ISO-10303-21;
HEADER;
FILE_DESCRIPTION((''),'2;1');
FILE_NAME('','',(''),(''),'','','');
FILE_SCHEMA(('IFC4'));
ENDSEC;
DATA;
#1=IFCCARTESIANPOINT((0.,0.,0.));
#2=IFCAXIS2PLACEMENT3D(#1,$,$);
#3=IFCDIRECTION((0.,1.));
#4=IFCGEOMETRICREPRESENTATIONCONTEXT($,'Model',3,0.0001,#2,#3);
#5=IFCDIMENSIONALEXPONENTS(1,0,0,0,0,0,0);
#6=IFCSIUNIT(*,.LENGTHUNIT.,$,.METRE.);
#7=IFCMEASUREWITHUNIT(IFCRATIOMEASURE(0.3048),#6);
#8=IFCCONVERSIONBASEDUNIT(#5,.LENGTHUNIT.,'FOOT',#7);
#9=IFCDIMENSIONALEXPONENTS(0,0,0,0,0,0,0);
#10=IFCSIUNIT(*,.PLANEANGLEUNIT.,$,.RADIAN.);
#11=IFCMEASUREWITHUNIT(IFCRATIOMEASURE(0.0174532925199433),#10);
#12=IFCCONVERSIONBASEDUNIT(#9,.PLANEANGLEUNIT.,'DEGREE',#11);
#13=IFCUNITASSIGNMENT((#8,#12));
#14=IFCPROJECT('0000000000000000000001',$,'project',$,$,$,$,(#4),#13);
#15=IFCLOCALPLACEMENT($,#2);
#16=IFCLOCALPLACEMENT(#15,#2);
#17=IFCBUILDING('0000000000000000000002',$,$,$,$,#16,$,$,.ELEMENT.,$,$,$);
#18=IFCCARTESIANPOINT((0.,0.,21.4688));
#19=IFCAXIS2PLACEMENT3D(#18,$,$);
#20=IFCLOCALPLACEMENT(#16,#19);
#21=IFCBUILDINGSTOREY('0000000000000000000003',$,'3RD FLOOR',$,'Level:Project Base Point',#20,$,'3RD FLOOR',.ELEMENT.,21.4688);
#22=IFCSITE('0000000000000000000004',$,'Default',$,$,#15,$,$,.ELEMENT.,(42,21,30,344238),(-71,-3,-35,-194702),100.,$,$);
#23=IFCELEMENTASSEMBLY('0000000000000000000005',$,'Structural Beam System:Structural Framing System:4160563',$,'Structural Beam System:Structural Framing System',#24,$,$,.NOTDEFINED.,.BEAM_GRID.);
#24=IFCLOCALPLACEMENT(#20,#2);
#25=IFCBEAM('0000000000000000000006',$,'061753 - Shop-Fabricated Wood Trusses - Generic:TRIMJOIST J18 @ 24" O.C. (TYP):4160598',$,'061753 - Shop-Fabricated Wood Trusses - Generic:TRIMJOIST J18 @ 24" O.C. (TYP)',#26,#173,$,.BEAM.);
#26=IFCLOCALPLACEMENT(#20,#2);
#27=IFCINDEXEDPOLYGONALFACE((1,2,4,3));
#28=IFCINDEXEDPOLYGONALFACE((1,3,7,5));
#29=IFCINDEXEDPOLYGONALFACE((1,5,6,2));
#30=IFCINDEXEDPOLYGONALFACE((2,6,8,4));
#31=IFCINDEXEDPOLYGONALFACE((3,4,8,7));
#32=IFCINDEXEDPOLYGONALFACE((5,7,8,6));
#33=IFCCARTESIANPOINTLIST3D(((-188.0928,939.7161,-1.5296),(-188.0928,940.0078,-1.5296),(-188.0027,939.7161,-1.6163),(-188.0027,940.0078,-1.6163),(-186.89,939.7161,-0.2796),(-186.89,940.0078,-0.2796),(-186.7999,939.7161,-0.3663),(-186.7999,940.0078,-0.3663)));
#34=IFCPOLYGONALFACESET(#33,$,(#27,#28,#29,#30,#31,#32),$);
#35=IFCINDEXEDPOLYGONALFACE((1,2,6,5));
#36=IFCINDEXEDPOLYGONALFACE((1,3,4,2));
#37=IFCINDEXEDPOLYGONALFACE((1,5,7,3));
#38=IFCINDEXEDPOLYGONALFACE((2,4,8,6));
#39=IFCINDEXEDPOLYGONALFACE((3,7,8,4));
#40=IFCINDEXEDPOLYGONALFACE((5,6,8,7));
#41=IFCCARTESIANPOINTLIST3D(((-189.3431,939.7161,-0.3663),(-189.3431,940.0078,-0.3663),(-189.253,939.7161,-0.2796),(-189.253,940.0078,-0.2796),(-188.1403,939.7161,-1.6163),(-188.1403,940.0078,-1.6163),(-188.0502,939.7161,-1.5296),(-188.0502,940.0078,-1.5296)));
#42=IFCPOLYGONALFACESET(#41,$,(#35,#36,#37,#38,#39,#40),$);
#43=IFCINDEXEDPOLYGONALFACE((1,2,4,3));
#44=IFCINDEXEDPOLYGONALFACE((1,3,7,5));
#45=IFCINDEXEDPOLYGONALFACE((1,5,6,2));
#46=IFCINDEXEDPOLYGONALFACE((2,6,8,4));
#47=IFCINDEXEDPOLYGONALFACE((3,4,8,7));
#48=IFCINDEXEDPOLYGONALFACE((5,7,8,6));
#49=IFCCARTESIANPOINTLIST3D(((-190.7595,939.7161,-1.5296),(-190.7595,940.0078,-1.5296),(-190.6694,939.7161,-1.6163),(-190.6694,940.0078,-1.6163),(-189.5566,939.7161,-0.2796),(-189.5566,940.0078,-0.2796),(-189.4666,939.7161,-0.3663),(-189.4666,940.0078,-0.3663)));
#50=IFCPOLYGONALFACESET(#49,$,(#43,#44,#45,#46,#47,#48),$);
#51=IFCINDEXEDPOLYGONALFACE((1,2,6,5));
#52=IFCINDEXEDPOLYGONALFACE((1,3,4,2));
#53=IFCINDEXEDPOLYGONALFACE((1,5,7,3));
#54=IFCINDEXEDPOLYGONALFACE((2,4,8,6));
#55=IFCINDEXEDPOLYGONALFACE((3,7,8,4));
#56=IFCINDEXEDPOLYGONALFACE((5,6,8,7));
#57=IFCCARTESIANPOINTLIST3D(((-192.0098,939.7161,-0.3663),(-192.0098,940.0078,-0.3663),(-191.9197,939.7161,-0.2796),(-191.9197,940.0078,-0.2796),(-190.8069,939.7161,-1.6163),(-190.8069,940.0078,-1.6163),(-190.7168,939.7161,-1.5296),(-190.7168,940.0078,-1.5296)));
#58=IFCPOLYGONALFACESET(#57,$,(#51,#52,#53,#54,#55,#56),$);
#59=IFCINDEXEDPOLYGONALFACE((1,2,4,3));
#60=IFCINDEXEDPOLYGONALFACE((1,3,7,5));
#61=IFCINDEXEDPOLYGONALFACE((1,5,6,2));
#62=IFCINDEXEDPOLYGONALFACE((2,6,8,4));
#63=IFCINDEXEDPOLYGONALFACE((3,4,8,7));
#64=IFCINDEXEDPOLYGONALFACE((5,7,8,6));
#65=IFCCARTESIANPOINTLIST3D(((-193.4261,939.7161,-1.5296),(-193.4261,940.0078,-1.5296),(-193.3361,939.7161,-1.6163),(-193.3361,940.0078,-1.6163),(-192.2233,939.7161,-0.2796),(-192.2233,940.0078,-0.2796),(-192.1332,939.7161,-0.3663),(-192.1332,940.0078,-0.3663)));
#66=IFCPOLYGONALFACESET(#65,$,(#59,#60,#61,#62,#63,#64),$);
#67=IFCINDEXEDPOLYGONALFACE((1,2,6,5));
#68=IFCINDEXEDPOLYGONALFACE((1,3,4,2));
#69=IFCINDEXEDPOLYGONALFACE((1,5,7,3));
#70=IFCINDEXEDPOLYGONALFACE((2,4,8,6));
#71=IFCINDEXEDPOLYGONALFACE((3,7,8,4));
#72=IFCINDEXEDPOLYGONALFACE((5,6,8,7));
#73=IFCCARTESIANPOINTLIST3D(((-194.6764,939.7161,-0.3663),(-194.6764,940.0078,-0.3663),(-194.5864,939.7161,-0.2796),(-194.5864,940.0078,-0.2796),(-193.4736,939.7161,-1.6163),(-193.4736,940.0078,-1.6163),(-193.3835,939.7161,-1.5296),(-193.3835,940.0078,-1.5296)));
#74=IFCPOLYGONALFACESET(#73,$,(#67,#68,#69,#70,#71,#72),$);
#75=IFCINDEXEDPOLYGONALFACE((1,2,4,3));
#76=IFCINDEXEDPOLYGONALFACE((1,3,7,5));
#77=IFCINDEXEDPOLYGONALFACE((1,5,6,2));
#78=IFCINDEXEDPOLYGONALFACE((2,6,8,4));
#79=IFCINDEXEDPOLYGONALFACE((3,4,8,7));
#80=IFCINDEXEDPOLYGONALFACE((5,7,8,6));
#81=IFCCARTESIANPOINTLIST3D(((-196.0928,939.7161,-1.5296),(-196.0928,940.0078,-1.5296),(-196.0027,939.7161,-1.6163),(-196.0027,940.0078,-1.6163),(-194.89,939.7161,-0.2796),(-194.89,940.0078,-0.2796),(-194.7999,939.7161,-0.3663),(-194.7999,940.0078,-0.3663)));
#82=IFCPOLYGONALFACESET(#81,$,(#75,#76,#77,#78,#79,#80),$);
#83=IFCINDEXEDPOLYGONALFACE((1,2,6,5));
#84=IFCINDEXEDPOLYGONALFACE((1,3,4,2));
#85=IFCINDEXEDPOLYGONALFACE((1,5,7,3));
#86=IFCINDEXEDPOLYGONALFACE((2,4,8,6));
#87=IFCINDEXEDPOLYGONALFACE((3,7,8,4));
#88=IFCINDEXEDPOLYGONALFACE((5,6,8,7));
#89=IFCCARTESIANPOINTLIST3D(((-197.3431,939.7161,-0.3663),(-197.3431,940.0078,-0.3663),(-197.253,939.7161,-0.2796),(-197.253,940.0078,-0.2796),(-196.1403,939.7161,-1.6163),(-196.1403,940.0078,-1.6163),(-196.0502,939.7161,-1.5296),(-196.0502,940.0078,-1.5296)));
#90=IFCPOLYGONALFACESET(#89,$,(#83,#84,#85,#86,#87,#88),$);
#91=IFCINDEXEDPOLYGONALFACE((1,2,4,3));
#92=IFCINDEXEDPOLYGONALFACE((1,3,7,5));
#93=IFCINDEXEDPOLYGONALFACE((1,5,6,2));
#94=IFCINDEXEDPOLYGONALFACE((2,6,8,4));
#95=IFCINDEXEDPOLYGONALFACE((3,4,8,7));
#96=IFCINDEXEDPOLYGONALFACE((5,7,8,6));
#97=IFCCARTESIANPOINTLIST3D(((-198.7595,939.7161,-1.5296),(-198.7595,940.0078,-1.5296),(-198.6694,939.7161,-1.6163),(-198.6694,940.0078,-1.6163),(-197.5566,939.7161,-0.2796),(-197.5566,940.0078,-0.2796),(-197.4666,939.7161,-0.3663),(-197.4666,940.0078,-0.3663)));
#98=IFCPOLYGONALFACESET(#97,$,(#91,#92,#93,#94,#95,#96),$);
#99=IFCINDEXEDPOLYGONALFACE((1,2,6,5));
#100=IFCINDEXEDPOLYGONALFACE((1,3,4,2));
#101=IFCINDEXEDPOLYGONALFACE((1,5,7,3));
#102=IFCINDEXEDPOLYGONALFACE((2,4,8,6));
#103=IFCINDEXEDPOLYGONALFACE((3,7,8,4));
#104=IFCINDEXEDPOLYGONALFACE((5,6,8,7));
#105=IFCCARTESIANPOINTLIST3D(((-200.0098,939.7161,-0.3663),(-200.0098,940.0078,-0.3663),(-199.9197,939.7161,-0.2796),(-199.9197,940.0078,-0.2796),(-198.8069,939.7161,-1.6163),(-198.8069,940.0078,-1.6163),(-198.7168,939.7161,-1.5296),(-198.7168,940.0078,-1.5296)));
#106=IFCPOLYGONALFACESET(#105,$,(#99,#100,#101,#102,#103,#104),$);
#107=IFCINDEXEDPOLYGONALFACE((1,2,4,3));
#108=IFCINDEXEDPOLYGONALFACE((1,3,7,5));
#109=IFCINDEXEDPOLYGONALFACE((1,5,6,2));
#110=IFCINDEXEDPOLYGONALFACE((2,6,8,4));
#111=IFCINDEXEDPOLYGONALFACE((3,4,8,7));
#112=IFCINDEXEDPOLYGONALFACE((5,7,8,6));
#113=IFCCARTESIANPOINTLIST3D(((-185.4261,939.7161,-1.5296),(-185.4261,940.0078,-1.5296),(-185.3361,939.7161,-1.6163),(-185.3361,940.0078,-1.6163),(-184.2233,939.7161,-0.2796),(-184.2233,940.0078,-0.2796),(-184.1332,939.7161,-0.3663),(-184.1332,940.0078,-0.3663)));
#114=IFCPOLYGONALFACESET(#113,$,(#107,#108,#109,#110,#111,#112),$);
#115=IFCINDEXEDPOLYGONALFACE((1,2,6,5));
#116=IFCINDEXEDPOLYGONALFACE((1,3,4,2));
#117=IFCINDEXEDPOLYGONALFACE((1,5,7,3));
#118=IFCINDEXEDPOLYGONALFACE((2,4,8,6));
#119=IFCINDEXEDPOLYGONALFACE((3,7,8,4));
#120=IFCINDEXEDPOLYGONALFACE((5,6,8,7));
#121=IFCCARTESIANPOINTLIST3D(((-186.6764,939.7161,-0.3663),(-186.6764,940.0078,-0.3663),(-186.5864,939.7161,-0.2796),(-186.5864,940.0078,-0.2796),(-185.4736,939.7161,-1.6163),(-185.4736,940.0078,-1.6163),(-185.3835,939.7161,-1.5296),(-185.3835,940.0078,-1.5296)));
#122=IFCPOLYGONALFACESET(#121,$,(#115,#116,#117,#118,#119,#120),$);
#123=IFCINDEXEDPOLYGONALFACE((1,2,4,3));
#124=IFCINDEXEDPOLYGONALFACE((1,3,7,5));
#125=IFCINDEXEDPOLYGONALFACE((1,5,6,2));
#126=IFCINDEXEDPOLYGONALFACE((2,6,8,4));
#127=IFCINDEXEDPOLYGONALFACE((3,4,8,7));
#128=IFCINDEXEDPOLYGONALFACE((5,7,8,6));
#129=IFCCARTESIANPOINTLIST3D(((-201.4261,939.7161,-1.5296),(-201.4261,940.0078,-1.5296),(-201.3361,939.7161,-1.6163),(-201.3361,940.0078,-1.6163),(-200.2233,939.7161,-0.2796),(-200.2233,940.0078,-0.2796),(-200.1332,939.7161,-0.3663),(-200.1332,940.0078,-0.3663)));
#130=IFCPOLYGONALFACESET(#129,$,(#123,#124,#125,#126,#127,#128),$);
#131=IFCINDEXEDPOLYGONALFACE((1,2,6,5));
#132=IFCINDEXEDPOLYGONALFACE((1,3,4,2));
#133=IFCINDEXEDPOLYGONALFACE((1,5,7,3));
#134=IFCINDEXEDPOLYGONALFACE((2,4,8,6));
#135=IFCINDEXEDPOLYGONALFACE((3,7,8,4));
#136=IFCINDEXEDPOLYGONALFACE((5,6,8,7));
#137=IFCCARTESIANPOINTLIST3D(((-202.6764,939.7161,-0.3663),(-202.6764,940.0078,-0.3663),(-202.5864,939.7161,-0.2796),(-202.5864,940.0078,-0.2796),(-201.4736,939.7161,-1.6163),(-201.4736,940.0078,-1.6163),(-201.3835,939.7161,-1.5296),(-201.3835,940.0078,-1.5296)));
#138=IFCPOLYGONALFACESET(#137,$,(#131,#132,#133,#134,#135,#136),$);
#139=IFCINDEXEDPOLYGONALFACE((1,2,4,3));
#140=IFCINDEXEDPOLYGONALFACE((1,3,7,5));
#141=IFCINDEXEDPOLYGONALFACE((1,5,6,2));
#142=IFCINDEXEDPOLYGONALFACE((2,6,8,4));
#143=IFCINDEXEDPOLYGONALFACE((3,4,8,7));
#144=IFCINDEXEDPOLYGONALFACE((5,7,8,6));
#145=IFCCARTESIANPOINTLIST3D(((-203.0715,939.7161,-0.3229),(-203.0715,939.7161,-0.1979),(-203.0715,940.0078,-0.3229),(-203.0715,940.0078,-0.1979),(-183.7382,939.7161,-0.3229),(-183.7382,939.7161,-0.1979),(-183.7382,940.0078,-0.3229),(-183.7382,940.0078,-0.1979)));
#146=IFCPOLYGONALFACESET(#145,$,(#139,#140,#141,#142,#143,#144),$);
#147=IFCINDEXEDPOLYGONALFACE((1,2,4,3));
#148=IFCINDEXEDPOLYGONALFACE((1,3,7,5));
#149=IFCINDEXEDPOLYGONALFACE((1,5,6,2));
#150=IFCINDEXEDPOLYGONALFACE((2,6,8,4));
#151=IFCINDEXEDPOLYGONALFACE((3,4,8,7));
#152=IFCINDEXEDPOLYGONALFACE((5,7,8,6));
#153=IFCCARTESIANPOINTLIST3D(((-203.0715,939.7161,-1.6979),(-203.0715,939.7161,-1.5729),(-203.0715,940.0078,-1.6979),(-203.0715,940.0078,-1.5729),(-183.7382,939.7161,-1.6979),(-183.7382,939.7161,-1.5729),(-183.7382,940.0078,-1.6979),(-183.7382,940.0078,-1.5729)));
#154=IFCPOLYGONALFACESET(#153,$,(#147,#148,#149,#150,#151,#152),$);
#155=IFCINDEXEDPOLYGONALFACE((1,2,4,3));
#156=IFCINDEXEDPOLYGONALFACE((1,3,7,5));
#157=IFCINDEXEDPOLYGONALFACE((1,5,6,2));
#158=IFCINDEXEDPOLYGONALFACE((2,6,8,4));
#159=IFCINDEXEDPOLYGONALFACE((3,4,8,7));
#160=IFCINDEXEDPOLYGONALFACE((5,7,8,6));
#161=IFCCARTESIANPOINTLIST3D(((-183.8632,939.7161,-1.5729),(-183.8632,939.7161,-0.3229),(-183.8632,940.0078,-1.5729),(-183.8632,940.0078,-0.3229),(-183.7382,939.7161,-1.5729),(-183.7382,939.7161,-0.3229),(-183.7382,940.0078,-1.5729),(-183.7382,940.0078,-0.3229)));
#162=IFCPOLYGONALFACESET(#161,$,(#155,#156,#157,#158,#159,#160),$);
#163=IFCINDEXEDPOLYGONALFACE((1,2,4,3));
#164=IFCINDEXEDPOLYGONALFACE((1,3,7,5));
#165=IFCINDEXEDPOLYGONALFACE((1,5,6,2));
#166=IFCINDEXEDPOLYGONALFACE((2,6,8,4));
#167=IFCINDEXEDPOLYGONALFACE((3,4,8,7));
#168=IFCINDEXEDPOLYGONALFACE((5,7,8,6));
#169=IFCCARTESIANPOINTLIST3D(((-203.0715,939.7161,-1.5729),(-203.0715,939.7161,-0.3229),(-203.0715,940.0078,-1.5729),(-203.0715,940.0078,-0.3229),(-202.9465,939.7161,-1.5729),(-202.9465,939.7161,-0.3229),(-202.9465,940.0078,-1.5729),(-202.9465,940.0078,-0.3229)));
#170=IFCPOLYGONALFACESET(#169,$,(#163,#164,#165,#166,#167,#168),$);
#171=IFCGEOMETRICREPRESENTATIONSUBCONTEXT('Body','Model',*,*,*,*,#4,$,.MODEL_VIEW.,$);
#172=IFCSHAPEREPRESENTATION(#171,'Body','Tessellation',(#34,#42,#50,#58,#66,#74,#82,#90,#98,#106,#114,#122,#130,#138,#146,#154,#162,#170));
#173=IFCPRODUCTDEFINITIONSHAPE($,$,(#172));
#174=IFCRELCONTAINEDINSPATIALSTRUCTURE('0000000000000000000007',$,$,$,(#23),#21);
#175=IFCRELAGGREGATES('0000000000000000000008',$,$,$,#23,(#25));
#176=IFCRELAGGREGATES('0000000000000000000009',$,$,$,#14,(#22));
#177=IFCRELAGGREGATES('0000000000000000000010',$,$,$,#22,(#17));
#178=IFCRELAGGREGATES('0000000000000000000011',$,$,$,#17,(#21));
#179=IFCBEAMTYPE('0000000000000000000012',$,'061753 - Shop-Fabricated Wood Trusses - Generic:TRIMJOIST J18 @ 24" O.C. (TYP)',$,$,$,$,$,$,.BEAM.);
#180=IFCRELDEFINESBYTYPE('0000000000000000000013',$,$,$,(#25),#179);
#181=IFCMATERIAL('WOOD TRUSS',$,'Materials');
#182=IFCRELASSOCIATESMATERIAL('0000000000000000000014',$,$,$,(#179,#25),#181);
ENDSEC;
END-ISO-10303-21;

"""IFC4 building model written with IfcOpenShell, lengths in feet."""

from ifc_helpers import new_model, entity, si_unit, converted_unit, direction, frame, frame_2d, origin, origin_2d_with_axis, place, context, subcontext, project, spatial, rectangle, extrude, source, transform, mapped, material, material_profile, profile_set, profile_usage, type_object, type_shapes, element, aggregate, save


model = new_model("IFC4")

# Units and contexts
model_context = context("Model", 3, precision=0.0001, world=origin(), true_north=direction((0.0, 1.0)))
body_context = subcontext(model_context, "Body", "Model", "MODEL_VIEW")
ifc_project = project(units=[converted_unit("LENGTHUNIT", "FOOT", entity("IfcRatioMeasure", 0.3048), si_unit("LENGTHUNIT", "METRE"), dimensions=[1, 0, 0, 0, 0, 0, 0]), converted_unit("PLANEANGLEUNIT", "DEGREE", entity("IfcRatioMeasure", 0.0174532925199433), si_unit("PLANEANGLEUNIT", "RADIAN"), dimensions=[0, 0, 0, 0, 0, 0, 0])], contexts=[model_context])

# Site, building, storey
site_placement = place(None, origin())
site = spatial("IfcSite", under=ifc_project, at=site_placement, Name="Default", CompositionType="ELEMENT", RefLatitude=(42, 21, 30, 344238), RefLongitude=(-71, -3, -35, -194702), RefElevation=100.0)
building_placement = place(site_placement, origin())
building = spatial("IfcBuilding", under=site, at=building_placement, CompositionType="ELEMENT")
storey_placement = place(building_placement, frame((0.0, 0.0, 21.4688)))
storey = spatial("IfcBuildingStorey", under=building, at=storey_placement, Name="3RD FLOOR", ObjectType="Level:Project Base Point", LongName="3RD FLOOR", CompositionType="ELEMENT", Elevation=21.4688)

# Element assembly, beam
ifc_material = material(Name="WOOD TRUSS", Category="Materials")
ifc_material_profile_1 = material_profile(ifc_material, rectangle(XDim=1.7347, YDim=0.125, at=frame_2d((0.0, 0.0), x_axis=(1.0, 0.0))), Name="TRIMJOIST J18 @ 24\" O.C. (TYP)")
ifc_material_profile_2 = material_profile(ifc_material, rectangle(XDim=1.7347, YDim=0.125, at=frame_2d((0.0, 0.0), x_axis=(1.0, 0.0))), Name="TRIMJOIST J18 @ 24\" O.C. (TYP)")
ifc_material_profile_3 = material_profile(ifc_material, rectangle(XDim=1.7347, YDim=0.125, at=frame_2d((0.0, 0.0), x_axis=(1.0, 0.0))), Name="TRIMJOIST J18 @ 24\" O.C. (TYP)")
ifc_material_profile_4 = material_profile(ifc_material, rectangle(XDim=1.7347, YDim=0.125, at=frame_2d((0.0, 0.0), x_axis=(1.0, 0.0))), Name="TRIMJOIST J18 @ 24\" O.C. (TYP)")
ifc_material_profile_5 = material_profile(ifc_material, rectangle(XDim=1.7347, YDim=0.125, at=frame_2d((0.0, 0.0), x_axis=(1.0, 0.0))), Name="TRIMJOIST J18 @ 24\" O.C. (TYP)")
ifc_material_profile_6 = material_profile(ifc_material, rectangle(XDim=1.7347, YDim=0.125, at=frame_2d((0.0, 0.0), x_axis=(1.0, 0.0))), Name="TRIMJOIST J18 @ 24\" O.C. (TYP)")
ifc_material_profile_7 = material_profile(ifc_material, rectangle(XDim=1.7347, YDim=0.125, at=frame_2d((0.0, 0.0), x_axis=(1.0, 0.0))), Name="TRIMJOIST J18 @ 24\" O.C. (TYP)")
ifc_material_profile_8 = material_profile(ifc_material, rectangle(XDim=1.7347, YDim=0.125, at=frame_2d((0.0, 0.0), x_axis=(1.0, 0.0))), Name="TRIMJOIST J18 @ 24\" O.C. (TYP)")
ifc_material_profile_9 = material_profile(ifc_material, rectangle(XDim=1.7347, YDim=0.125, at=frame_2d((0.0, 0.0), x_axis=(1.0, 0.0))), Name="TRIMJOIST J18 @ 24\" O.C. (TYP)")
ifc_material_profile_10 = material_profile(ifc_material, rectangle(XDim=1.7347, YDim=0.125, at=origin_2d_with_axis()), Name="TRIMJOIST J18 @ 24\" O.C. (TYP)")
ifc_material_profile_11 = material_profile(ifc_material, rectangle(XDim=0.125, YDim=0.2917, at=origin_2d_with_axis()), Name="TRIMJOIST J18 @ 24\" O.C. (TYP)")
ifc_material_profile_12 = material_profile(ifc_material, rectangle(XDim=0.125, YDim=0.2917, at=origin_2d_with_axis()), Name="TRIMJOIST J18 @ 24\" O.C. (TYP)")
ifc_material_profile_13 = material_profile(ifc_material, rectangle(XDim=1.25, YDim=0.2917, at=origin_2d_with_axis()), Name="TRIMJOIST J18 @ 24\" O.C. (TYP)")
ifc_material_profile_14 = material_profile(ifc_material, rectangle(XDim=1.25, YDim=0.2917, at=origin_2d_with_axis()), Name="TRIMJOIST J18 @ 24\" O.C. (TYP)")
ifc_profile_set = profile_set([ifc_material_profile_1, ifc_material_profile_2, ifc_material_profile_3, ifc_material_profile_4, ifc_material_profile_5, ifc_material_profile_6, ifc_material_profile_7, ifc_material_profile_8, ifc_material_profile_9, ifc_material_profile_10, ifc_material_profile_11, ifc_material_profile_12, ifc_material_profile_13, ifc_material_profile_14], Name="TRIMJOIST J18 @ 24\" O.C. (TYP)")
beam_type_1 = type_object("IfcBeamType", Name="061753 - Shop-Fabricated Wood Trusses - Generic:TRIMJOIST J18 @ 24\" O.C. (TYP)", PredefinedType="BEAM", material=ifc_profile_set)
shared_shape_1 = source(origin(), body_context, "Body", "SweptSolid", [
    extrude(rectangle(XDim=1.7347, YDim=0.125, at=frame_2d((0.0, 0.0), x_axis=(1.0, 0.0))), frame((5.9585, -0.1458, 0.0), z_axis=(0.0, 1.0, 0.0), x_axis=(0.693383, 0.0, 0.720569)), (0.0, 0.0, 1.0), 0.2917),
    extrude(rectangle(XDim=1.7347, YDim=0.125, at=origin_2d_with_axis()), frame((4.7082, -0.1458, 0.0), z_axis=(0.0, 1.0, 0.0), x_axis=(0.693383, 0.0, -0.720569)), (0.0, 0.0, 1.0), 0.2917),
    extrude(rectangle(XDim=1.7347, YDim=0.125, at=frame_2d((0.0, 0.0), x_axis=(1.0, 0.0))), frame((3.2918, -0.1458, 0.0), z_axis=(0.0, 1.0, 0.0), x_axis=(0.693383, 0.0, 0.720569)), (0.0, 0.0, 1.0), 0.2917),
    extrude(rectangle(XDim=1.7347, YDim=0.125, at=frame_2d((0.0, 0.0), x_axis=(1.0, 0.0))), frame((2.0415, -0.1458, 0.0), z_axis=(0.0, 1.0, 0.0), x_axis=(0.693383, 0.0, -0.720569)), (0.0, 0.0, 1.0), 0.2917),
    extrude(rectangle(XDim=1.7347, YDim=0.125, at=frame_2d((0.0, 0.0), x_axis=(1.0, 0.0))), frame((0.6251, -0.1458, 0.0), z_axis=(0.0, 1.0, 0.0), x_axis=(0.693383, 0.0, 0.720569)), (0.0, 0.0, 1.0), 0.2917),
    extrude(rectangle(XDim=1.7347, YDim=0.125, at=frame_2d((0.0, 0.0), x_axis=(1.0, 0.0))), frame((-0.6251, -0.1458, 0.0), z_axis=(0.0, 1.0, 0.0), x_axis=(0.693383, 0.0, -0.720569)), (0.0, 0.0, 1.0), 0.2917),
    extrude(rectangle(XDim=1.7347, YDim=0.125, at=frame_2d((0.0, 0.0), x_axis=(1.0, 0.0))), frame((-2.0415, -0.1458, 0.0), z_axis=(0.0, 1.0, 0.0), x_axis=(0.693383, 0.0, 0.720569)), (0.0, 0.0, 1.0), 0.2917),
    extrude(rectangle(XDim=1.7347, YDim=0.125, at=origin_2d_with_axis()), frame((-3.2918, -0.1458, 0.0), z_axis=(0.0, 1.0, 0.0), x_axis=(0.693383, 0.0, -0.720569)), (0.0, 0.0, 1.0), 0.2917),
    extrude(rectangle(XDim=1.7347, YDim=0.125, at=frame_2d((0.0, 0.0), x_axis=(1.0, 0.0))), frame((-4.7082, -0.1458, 0.0), z_axis=(0.0, 1.0, 0.0), x_axis=(0.693383, 0.0, 0.720569)), (0.0, 0.0, 1.0), 0.2917),
    extrude(rectangle(XDim=1.7347, YDim=0.125, at=frame_2d((0.0, 0.0), x_axis=(1.0, 0.0))), frame((-5.9585, -0.1458, 0.0), z_axis=(0.0, 1.0, 0.0), x_axis=(0.693383, 0.0, -0.720569)), (0.0, 0.0, 1.0), 0.2917),
    extrude(rectangle(XDim=1.7347, YDim=0.125, at=frame_2d((0.0, 0.0), x_axis=(1.0, 0.0))), frame((8.6251, -0.1458, 0.0), z_axis=(0.0, 1.0, 0.0), x_axis=(0.693383, 0.0, 0.720569)), (0.0, 0.0, 1.0), 0.2917),
    extrude(rectangle(XDim=1.7347, YDim=0.125, at=origin_2d_with_axis()), frame((7.3749, -0.1458, 0.0), z_axis=(0.0, 1.0, 0.0), x_axis=(0.693383, 0.0, -0.720569)), (0.0, 0.0, 1.0), 0.2917),
    extrude(rectangle(XDim=1.7347, YDim=0.125, at=frame_2d((0.0, 0.0), x_axis=(1.0, 0.0))), frame((-7.3749, -0.1458, 0.0), z_axis=(0.0, 1.0, 0.0), x_axis=(0.693383, 0.0, 0.720569)), (0.0, 0.0, 1.0), 0.2917),
    extrude(rectangle(XDim=1.7347, YDim=0.125, at=origin_2d_with_axis()), frame((-8.6251, -0.1458, 0.0), z_axis=(0.0, 1.0, 0.0), x_axis=(0.693383, 0.0, -0.720569)), (0.0, 0.0, 1.0), 0.2917),
    extrude(rectangle(XDim=0.125, YDim=0.2917, at=origin_2d_with_axis()), frame((-9.6667, 0.0, 0.6875), z_axis=(1.0, 0.0, 0.0), x_axis=(0.0, 0.0, -1.0)), (0.0, 0.0, 1.0), 19.3333),
    extrude(rectangle(XDim=0.125, YDim=0.2917, at=origin_2d_with_axis()), frame((-9.6667, 0.0, -0.6875), z_axis=(1.0, 0.0, 0.0), x_axis=(0.0, 0.0, -1.0)), (0.0, 0.0, 1.0), 19.3333),
    extrude(rectangle(XDim=1.25, YDim=0.2917, at=origin_2d_with_axis()), frame((9.5417, 0.0, 0.0), z_axis=(1.0, 0.0, 0.0), x_axis=(0.0, 0.0, -1.0)), (0.0, 0.0, 1.0), 0.125),
    extrude(rectangle(XDim=1.25, YDim=0.2917, at=origin_2d_with_axis()), frame((-9.6667, 0.0, 0.0), z_axis=(1.0, 0.0, 0.0), x_axis=(0.0, 0.0, -1.0)), (0.0, 0.0, 1.0), 0.125),
])
type_shapes(beam_type_1, [shared_shape_1])
assembly_1_placement = place(storey_placement, origin())
assembly_1 = element("IfcElementAssembly", 1, at=assembly_1_placement, inside=storey, Name="Structural Beam System:Structural Framing System:4160563", ObjectType="Structural Beam System:Structural Framing System", AssemblyPlace="NOTDEFINED", PredefinedType="BEAM_GRID")
ifc_profile_usage_1 = profile_usage(ifc_profile_set, cardinal=8)
beam_1_placement = place(assembly_1_placement, frame((-193.4048, 939.8619, -0.9479)))
beam_1 = element("IfcBeam", 2, at=beam_1_placement, type_object=beam_type_1, material=ifc_profile_usage_1, Name="061753 - Shop-Fabricated Wood Trusses - Generic:TRIMJOIST J18 @ 24\" O.C. (TYP):4160598", ObjectType="061753 - Shop-Fabricated Wood Trusses - Generic:TRIMJOIST J18 @ 24\" O.C. (TYP)", PredefinedType="BEAM", context=body_context, shape_type="MappedRepresentation", body=[
    mapped(shared_shape_1, transform((0.0, 0.0, 0.0), scale=1.0)),
])
aggregate(assembly_1, [beam_1])

save(model, "model.ifc")
